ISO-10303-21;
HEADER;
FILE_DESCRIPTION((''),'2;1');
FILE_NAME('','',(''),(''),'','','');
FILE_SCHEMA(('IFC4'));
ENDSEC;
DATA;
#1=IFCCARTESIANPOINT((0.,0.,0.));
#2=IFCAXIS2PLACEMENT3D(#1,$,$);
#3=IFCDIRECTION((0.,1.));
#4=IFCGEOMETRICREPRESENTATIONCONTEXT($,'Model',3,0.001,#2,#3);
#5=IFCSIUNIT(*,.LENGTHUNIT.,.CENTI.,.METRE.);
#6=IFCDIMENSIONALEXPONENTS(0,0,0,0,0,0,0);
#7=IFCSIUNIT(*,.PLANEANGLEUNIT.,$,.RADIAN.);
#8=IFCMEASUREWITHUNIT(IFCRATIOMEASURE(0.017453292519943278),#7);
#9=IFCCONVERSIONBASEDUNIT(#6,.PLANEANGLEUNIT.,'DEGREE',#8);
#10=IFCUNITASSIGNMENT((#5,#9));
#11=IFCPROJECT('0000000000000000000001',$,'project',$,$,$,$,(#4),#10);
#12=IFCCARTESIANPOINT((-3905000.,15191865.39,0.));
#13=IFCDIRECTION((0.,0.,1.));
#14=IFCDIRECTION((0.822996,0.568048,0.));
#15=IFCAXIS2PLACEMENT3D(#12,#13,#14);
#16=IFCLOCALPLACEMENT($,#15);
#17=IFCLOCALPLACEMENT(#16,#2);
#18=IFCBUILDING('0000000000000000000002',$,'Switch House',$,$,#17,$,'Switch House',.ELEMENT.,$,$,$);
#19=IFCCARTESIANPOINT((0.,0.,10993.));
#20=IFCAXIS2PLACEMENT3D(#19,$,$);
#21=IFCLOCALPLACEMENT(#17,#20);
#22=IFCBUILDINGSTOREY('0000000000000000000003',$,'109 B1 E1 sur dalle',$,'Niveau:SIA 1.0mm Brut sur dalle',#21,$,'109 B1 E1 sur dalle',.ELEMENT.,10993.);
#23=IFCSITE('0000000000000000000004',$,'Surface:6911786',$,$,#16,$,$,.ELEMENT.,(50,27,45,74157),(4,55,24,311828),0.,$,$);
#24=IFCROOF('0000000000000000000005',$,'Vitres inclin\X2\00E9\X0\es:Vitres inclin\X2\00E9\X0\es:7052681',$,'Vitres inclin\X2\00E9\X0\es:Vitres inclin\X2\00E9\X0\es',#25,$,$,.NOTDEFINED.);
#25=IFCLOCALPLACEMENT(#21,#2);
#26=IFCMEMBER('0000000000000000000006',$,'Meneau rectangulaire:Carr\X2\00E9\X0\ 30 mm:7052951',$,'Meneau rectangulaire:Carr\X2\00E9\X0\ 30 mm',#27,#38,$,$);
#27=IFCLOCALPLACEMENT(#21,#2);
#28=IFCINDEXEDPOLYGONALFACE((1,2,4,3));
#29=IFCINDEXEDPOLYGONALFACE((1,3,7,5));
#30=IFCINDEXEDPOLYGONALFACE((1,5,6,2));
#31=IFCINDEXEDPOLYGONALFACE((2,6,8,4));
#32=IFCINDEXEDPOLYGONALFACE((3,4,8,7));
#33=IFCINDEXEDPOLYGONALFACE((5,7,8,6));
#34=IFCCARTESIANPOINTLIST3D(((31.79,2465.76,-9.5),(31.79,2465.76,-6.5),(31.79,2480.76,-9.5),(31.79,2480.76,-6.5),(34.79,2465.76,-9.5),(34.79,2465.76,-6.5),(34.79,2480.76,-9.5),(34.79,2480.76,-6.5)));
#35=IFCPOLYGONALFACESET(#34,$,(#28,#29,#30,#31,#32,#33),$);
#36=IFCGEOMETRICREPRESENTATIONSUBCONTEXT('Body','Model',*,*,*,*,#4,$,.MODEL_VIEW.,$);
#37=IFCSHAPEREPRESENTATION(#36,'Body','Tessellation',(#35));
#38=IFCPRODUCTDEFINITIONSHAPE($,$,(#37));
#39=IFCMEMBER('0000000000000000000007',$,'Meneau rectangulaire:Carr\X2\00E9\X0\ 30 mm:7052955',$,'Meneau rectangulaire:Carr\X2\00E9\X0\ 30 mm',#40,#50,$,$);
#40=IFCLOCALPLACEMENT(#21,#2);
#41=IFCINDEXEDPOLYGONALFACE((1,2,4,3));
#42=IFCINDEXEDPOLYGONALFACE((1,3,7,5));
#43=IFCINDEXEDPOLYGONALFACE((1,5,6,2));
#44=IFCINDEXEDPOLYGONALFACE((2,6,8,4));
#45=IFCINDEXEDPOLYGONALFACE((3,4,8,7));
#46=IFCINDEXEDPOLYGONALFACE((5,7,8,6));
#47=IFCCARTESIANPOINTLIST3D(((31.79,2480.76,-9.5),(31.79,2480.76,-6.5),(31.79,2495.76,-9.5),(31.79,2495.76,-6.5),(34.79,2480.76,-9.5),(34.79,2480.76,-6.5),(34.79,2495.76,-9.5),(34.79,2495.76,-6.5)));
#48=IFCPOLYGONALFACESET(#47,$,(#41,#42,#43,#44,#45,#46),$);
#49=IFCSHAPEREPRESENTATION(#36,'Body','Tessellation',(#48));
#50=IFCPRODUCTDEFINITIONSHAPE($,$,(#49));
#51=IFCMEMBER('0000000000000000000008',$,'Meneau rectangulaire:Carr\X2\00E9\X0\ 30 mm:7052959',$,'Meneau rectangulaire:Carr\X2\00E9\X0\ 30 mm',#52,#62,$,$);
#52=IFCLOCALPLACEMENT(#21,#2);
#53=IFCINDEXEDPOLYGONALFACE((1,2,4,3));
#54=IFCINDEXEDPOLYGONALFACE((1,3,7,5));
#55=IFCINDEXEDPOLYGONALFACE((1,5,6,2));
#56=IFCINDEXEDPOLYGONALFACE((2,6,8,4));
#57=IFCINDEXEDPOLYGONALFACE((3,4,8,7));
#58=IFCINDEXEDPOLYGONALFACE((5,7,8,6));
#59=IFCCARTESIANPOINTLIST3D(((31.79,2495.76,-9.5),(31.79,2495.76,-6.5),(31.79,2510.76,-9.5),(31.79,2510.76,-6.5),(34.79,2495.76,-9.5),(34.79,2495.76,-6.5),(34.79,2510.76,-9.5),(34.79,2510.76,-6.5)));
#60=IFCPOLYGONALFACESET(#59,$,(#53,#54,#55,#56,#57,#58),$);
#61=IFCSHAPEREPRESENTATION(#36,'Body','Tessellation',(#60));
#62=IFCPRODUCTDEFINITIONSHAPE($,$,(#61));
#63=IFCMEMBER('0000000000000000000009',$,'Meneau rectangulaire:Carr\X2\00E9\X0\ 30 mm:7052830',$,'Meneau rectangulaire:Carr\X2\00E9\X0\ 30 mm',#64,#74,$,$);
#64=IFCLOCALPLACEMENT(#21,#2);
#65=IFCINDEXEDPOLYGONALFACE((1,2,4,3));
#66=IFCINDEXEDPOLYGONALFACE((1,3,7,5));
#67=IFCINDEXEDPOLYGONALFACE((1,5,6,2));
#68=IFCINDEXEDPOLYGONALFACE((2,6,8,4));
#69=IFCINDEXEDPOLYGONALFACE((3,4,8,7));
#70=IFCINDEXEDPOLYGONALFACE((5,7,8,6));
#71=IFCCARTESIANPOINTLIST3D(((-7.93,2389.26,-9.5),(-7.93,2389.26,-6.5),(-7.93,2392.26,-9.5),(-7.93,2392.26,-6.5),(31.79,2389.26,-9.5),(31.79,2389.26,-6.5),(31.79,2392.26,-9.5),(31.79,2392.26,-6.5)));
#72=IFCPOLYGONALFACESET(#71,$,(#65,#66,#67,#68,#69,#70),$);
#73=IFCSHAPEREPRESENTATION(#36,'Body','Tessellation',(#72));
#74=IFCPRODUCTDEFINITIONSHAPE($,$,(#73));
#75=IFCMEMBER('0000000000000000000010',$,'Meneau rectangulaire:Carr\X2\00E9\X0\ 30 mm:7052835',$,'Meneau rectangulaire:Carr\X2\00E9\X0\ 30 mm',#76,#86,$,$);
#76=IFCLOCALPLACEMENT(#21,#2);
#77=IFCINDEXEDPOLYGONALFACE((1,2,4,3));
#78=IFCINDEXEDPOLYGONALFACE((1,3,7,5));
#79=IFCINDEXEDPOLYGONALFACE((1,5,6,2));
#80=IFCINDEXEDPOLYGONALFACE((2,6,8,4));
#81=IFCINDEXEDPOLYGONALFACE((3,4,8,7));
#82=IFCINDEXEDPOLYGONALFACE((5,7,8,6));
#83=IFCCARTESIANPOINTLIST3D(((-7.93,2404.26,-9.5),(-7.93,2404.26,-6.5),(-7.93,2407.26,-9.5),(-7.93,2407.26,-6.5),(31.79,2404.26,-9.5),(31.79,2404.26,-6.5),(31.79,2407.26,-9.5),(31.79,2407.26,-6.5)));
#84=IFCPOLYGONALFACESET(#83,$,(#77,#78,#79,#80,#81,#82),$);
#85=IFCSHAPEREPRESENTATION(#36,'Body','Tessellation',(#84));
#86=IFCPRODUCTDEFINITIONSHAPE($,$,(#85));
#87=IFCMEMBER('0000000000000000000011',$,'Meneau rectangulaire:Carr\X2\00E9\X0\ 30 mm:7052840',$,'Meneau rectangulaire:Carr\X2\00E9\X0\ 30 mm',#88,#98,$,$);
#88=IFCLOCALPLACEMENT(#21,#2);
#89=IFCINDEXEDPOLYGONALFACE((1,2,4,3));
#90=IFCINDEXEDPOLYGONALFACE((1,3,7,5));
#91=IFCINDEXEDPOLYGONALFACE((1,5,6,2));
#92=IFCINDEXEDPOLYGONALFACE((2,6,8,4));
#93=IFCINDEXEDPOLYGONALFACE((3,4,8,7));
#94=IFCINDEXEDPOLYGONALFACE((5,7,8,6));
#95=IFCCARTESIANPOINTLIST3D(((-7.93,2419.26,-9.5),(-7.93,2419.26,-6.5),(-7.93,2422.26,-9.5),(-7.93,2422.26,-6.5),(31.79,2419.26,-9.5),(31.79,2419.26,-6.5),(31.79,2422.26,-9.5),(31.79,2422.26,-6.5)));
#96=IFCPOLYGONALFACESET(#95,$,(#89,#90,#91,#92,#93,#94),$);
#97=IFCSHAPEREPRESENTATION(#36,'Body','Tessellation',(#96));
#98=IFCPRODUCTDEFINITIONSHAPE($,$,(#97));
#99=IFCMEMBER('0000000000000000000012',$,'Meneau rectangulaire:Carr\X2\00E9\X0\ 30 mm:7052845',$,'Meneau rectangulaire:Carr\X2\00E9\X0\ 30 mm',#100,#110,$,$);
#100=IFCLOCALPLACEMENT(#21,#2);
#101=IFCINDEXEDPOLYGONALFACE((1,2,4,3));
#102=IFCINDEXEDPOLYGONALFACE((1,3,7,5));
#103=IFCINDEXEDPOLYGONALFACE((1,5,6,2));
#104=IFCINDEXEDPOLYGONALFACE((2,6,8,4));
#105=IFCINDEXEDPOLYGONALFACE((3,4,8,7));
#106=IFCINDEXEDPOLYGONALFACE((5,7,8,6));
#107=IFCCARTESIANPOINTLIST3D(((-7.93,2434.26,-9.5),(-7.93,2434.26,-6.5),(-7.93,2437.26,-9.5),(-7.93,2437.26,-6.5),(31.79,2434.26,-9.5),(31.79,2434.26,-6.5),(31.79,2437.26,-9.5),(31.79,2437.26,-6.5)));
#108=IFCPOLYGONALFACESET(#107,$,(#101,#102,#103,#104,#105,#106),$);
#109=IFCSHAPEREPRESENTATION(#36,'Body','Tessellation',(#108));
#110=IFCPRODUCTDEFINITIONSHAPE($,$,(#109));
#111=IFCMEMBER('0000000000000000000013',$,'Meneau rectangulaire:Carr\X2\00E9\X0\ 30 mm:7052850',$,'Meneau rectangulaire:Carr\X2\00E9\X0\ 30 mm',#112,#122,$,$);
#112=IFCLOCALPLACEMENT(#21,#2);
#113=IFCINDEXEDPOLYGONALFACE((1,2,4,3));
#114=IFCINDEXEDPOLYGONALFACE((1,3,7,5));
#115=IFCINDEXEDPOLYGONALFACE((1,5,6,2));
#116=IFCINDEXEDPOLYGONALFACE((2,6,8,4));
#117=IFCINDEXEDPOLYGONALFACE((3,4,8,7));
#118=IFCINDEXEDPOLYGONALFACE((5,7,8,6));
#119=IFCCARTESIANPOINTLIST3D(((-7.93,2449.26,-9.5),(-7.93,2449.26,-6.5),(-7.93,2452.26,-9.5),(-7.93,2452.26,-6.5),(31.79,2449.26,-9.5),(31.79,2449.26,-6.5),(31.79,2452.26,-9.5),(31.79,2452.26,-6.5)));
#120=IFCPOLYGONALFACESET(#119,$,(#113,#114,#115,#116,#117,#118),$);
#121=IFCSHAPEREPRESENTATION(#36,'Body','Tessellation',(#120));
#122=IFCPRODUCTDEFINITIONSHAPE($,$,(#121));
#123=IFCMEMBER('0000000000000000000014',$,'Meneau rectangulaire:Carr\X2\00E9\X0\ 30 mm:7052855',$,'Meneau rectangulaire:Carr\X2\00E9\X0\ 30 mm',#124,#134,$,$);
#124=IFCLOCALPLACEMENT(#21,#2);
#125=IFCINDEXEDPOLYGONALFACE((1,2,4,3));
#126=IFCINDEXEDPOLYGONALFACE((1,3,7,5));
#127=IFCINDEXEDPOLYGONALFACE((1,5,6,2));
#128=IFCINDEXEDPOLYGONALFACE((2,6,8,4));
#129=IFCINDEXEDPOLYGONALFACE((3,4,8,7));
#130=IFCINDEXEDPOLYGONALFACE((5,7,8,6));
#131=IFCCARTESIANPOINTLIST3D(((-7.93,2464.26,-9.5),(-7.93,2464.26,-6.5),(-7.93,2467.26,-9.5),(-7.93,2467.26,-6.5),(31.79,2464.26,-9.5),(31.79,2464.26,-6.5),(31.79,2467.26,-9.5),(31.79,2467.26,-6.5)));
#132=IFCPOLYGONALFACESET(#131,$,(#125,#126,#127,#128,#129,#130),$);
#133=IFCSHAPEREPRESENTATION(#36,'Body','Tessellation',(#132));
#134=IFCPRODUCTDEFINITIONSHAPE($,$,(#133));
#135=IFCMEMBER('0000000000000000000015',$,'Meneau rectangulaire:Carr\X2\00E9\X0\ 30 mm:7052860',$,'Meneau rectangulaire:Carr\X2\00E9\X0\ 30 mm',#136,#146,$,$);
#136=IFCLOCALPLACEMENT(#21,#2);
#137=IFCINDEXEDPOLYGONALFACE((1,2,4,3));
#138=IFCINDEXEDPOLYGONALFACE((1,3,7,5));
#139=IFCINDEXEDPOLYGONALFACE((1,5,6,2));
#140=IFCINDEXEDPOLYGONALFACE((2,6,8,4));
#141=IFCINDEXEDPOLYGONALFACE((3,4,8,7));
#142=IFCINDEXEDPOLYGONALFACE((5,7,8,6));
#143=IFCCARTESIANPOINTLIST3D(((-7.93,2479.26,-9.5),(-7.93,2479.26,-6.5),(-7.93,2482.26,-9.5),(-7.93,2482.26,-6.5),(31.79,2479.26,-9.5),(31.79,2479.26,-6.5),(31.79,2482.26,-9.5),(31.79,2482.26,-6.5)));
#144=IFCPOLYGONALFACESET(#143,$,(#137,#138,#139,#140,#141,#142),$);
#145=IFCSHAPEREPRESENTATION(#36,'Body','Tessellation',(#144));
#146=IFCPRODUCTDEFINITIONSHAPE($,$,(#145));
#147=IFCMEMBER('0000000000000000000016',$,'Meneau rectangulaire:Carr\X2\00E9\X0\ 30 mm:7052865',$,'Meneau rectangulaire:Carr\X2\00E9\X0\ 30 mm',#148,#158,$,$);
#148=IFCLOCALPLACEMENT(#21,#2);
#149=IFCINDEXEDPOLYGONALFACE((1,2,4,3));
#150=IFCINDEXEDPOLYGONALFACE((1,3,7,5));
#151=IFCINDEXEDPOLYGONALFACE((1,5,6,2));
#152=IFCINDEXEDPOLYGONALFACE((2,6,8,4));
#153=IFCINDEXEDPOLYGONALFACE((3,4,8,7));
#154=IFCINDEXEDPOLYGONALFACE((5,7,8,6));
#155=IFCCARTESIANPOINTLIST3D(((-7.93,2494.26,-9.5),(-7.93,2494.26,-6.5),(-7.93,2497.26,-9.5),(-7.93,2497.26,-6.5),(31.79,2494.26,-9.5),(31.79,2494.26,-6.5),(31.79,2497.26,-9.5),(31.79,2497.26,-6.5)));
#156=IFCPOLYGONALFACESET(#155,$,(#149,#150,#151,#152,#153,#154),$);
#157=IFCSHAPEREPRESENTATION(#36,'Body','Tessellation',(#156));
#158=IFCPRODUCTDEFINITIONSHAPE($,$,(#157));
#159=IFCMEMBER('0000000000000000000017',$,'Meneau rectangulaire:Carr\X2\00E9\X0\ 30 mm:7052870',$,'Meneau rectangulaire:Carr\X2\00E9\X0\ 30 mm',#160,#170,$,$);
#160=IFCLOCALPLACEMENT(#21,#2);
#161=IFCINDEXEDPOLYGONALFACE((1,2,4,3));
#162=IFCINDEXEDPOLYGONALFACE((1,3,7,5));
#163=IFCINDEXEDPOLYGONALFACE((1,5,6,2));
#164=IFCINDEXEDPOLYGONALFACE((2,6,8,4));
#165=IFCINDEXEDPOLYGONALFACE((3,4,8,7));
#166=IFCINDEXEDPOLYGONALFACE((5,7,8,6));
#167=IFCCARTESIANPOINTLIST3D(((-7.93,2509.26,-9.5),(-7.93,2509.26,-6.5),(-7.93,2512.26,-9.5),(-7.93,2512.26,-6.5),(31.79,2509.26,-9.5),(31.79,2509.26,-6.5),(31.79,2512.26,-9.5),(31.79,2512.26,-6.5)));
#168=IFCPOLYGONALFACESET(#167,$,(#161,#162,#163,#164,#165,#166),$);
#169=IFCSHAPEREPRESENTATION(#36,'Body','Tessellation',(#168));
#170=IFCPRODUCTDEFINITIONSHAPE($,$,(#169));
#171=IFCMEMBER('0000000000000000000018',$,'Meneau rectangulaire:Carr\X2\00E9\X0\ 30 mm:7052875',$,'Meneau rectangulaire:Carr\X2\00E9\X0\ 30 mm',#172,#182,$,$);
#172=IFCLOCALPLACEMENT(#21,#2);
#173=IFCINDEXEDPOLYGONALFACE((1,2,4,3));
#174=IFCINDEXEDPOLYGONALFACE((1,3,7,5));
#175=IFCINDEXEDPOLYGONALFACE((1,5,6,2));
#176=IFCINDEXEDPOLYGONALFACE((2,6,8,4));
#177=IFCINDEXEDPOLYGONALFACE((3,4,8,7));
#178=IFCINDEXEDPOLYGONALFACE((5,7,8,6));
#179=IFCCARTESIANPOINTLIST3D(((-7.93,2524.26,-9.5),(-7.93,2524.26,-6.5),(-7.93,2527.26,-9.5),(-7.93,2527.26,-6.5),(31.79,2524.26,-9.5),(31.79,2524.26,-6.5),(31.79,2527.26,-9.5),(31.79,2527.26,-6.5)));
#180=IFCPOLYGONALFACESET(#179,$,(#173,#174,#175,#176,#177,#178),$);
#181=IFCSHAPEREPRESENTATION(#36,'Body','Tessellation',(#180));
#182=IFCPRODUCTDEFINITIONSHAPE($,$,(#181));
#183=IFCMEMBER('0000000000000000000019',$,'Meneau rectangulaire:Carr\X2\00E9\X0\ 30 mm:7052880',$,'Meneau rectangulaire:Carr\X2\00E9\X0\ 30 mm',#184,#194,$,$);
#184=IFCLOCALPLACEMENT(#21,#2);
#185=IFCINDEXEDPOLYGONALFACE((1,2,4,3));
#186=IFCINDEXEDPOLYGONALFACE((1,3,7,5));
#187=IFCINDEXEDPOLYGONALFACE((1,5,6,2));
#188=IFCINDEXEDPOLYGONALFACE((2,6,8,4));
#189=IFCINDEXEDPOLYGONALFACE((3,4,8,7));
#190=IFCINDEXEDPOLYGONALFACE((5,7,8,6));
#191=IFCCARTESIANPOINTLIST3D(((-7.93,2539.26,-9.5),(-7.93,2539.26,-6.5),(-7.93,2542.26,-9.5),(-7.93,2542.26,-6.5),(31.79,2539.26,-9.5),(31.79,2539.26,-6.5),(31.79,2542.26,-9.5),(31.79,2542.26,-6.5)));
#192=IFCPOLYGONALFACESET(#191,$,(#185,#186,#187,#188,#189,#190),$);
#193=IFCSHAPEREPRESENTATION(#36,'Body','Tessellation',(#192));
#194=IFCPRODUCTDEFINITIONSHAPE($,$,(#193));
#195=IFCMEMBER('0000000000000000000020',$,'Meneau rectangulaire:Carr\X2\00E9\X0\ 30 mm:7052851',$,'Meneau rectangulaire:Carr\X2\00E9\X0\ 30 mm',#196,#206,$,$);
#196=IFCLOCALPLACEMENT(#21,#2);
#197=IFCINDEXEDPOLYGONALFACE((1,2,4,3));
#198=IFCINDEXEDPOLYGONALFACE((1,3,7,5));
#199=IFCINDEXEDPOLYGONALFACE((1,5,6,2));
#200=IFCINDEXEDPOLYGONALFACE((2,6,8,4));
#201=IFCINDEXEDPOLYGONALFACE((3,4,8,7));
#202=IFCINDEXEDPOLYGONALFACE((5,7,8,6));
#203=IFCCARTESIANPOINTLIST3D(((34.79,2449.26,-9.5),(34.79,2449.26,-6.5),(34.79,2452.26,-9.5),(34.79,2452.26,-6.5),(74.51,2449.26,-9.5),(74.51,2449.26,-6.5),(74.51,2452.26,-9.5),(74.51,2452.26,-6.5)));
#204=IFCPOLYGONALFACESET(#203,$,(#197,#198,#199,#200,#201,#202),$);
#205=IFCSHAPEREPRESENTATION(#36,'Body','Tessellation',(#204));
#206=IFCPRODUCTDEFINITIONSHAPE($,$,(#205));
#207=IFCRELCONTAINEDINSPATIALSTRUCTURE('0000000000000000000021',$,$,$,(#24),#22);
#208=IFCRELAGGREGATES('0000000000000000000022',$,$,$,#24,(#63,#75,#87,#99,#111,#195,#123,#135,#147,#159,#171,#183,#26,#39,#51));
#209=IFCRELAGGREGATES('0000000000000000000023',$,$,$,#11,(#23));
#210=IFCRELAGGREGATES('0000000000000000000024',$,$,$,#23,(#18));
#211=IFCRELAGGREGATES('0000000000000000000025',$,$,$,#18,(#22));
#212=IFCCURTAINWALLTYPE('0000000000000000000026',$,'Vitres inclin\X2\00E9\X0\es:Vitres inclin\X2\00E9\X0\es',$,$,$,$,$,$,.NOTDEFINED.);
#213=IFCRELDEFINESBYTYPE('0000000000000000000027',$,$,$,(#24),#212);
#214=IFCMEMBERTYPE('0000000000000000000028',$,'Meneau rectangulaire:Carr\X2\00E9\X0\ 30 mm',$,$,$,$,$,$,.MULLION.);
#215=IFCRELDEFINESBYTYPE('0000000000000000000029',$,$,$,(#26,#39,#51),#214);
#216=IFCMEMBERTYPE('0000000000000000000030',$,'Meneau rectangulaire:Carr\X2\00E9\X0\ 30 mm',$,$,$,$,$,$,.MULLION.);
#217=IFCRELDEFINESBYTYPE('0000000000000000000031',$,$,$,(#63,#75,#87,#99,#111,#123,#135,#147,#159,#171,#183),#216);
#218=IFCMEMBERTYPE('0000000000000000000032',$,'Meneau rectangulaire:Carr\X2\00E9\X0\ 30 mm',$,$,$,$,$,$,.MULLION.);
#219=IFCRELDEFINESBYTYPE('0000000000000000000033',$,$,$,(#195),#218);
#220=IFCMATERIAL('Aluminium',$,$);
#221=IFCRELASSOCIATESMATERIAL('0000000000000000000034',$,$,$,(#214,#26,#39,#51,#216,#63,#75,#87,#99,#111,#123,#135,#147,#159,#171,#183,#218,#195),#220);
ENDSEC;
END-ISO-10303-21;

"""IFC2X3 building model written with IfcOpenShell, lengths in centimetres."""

from ifc_helpers import new_model, entity, si_unit, converted_unit, direction, frame, origin, origin_2d_with_axis, place, context, subcontext, project, spatial, rectangle, extrude, source, transform, mapped, material, type_object, type_shapes, element, aggregate, save


model = new_model("IFC2X3")

# Units and contexts
model_context = context("Model", 3, precision=0.001, world=origin(), true_north=direction((0.0, 1.0)))
body_context = subcontext(model_context, "Body", "Model", "MODEL_VIEW")
ifc_project = project(units=[si_unit("LENGTHUNIT", "METRE", prefix="CENTI"), converted_unit("PLANEANGLEUNIT", "DEGREE", entity("IfcRatioMeasure", 0.017453292519943278), si_unit("PLANEANGLEUNIT", "RADIAN"), dimensions=[0, 0, 0, 0, 0, 0, 0])], contexts=[model_context])

# Site, building, storey
site_placement = place(None, frame((-3905000.0, 15191865.39, 0.0), z_axis=(0.0, 0.0, 1.0), x_axis=(0.822996, 0.568048, 0.0)))
site = spatial("IfcSite", under=ifc_project, at=site_placement, Name="Surface:6911786", CompositionType="ELEMENT", RefLatitude=(50, 27, 45, 74157), RefLongitude=(4, 55, 24, 311828), RefElevation=0.0)
building_placement = place(site_placement, origin())
building = spatial("IfcBuilding", under=site, at=building_placement, Name="Switch House", LongName="Switch House", CompositionType="ELEMENT")
storey_placement = place(building_placement, frame((0.0, 0.0, 10993.0)))
storey = spatial("IfcBuildingStorey", under=building, at=storey_placement, Name="109 B1 E1 sur dalle", ObjectType="Niveau:SIA 1.0mm Brut sur dalle", LongName="109 B1 E1 sur dalle", CompositionType="ELEMENT", Elevation=10993.0)

# Roof, members
curtain_wall_type = type_object("IfcCurtainWallType", Name="Vitres inclinées:Vitres inclinées", PredefinedType="NOTDEFINED")
ifc_material = material(Name="Aluminium")
member_type_1 = type_object("IfcMemberType", Name="Meneau rectangulaire:Carré 30 mm", PredefinedType="MULLION", material=ifc_material)
shared_shape_1 = source(origin(), body_context, "Body", "SweptSolid", [
    extrude(rectangle(XDim=3.0, YDim=3.0, at=origin_2d_with_axis()), frame((0.0, 0.0, -15.0), z_axis=(0.0, 0.0, 1.0), x_axis=(0.0, -1.0, 0.0)), (0.0, 0.0, 1.0), 15.0),
])
type_shapes(member_type_1, [shared_shape_1])
roof_1_placement = place(storey_placement, frame((0.0, 0.0, -10993.0)))
roof_1 = element("IfcRoof", 1, at=roof_1_placement, inside=storey, type_object=curtain_wall_type, Name="Vitres inclinées:Vitres inclinées:7052681", ObjectType="Vitres inclinées:Vitres inclinées", ShapeType="NOTDEFINED")
member_1_placement = place(roof_1_placement, frame((33.29, 2480.76, 10985.0), z_axis=(0.0, 1.0, 0.0), x_axis=(1.0, 0.0, 0.0)))
member_1 = element("IfcMember", 2, at=member_1_placement, type_object=member_type_1, material=ifc_material, Name="Meneau rectangulaire:Carré 30 mm:7052951", ObjectType="Meneau rectangulaire:Carré 30 mm", context=body_context, shape_type="MappedRepresentation", body=[
    mapped(shared_shape_1, transform((0.0, 0.0, 0.0), scale=1.0)),
])
member_2_placement = place(roof_1_placement, frame((33.29, 2495.76, 10985.0), z_axis=(0.0, 1.0, 0.0), x_axis=(1.0, 0.0, 0.0)))
member_2 = element("IfcMember", 3, at=member_2_placement, type_object=member_type_1, material=ifc_material, Name="Meneau rectangulaire:Carré 30 mm:7052955", ObjectType="Meneau rectangulaire:Carré 30 mm", context=body_context, shape_type="MappedRepresentation", body=[
    mapped(shared_shape_1, transform((0.0, 0.0, 0.0), scale=1.0)),
])
member_3_placement = place(roof_1_placement, frame((33.29, 2510.76, 10985.0), z_axis=(0.0, 1.0, 0.0), x_axis=(1.0, 0.0, 0.0)))
member_3 = element("IfcMember", 4, at=member_3_placement, type_object=member_type_1, material=ifc_material, Name="Meneau rectangulaire:Carré 30 mm:7052959", ObjectType="Meneau rectangulaire:Carré 30 mm", context=body_context, shape_type="MappedRepresentation", body=[
    mapped(shared_shape_1, transform((0.0, 0.0, 0.0), scale=1.0)),
])
member_type_2 = type_object("IfcMemberType", Name="Meneau rectangulaire:Carré 30 mm", PredefinedType="MULLION", material=ifc_material)
shared_shape_2 = source(origin(), body_context, "Body", "SweptSolid", [
    extrude(rectangle(XDim=3.0, YDim=3.0, at=origin_2d_with_axis()), frame((0.0, 0.0, -39.72), z_axis=(0.0, 0.0, 1.0), x_axis=(0.0, -1.0, 0.0)), (0.0, 0.0, 1.0), 39.72),
])
type_shapes(member_type_2, [shared_shape_2])
member_4_placement = place(roof_1_placement, frame((-7.93, 2390.76, 10985.0), z_axis=(-1.0, 0.0, 0.0), x_axis=(0.0, 1.0, 0.0)))
member_4 = element("IfcMember", 5, at=member_4_placement, type_object=member_type_2, material=ifc_material, Name="Meneau rectangulaire:Carré 30 mm:7052830", ObjectType="Meneau rectangulaire:Carré 30 mm", context=body_context, shape_type="MappedRepresentation", body=[
    mapped(shared_shape_2, transform((0.0, 0.0, 0.0), scale=1.0)),
])
member_5_placement = place(roof_1_placement, frame((-7.93, 2405.76, 10985.0), z_axis=(-1.0, 0.0, 0.0), x_axis=(0.0, 1.0, 0.0)))
member_5 = element("IfcMember", 6, at=member_5_placement, type_object=member_type_2, material=ifc_material, Name="Meneau rectangulaire:Carré 30 mm:7052835", ObjectType="Meneau rectangulaire:Carré 30 mm", context=body_context, shape_type="MappedRepresentation", body=[
    mapped(shared_shape_2, transform((0.0, 0.0, 0.0), scale=1.0)),
])
member_6_placement = place(roof_1_placement, frame((-7.93, 2420.76, 10985.0), z_axis=(-1.0, 0.0, 0.0), x_axis=(0.0, 1.0, 0.0)))
member_6 = element("IfcMember", 7, at=member_6_placement, type_object=member_type_2, material=ifc_material, Name="Meneau rectangulaire:Carré 30 mm:7052840", ObjectType="Meneau rectangulaire:Carré 30 mm", context=body_context, shape_type="MappedRepresentation", body=[
    mapped(shared_shape_2, transform((0.0, 0.0, 0.0), scale=1.0)),
])
member_7_placement = place(roof_1_placement, frame((-7.93, 2435.76, 10985.0), z_axis=(-1.0, 0.0, 0.0), x_axis=(0.0, 1.0, 0.0)))
member_7 = element("IfcMember", 8, at=member_7_placement, type_object=member_type_2, material=ifc_material, Name="Meneau rectangulaire:Carré 30 mm:7052845", ObjectType="Meneau rectangulaire:Carré 30 mm", context=body_context, shape_type="MappedRepresentation", body=[
    mapped(shared_shape_2, transform((0.0, 0.0, 0.0), scale=1.0)),
])
member_8_placement = place(roof_1_placement, frame((-7.93, 2450.76, 10985.0), z_axis=(-1.0, 0.0, 0.0), x_axis=(0.0, 1.0, 0.0)))
member_8 = element("IfcMember", 9, at=member_8_placement, type_object=member_type_2, material=ifc_material, Name="Meneau rectangulaire:Carré 30 mm:7052850", ObjectType="Meneau rectangulaire:Carré 30 mm", context=body_context, shape_type="MappedRepresentation", body=[
    mapped(shared_shape_2, transform((0.0, 0.0, 0.0), scale=1.0)),
])
member_9_placement = place(roof_1_placement, frame((-7.93, 2465.76, 10985.0), z_axis=(-1.0, 0.0, 0.0), x_axis=(0.0, 1.0, 0.0)))
member_9 = element("IfcMember", 10, at=member_9_placement, type_object=member_type_2, material=ifc_material, Name="Meneau rectangulaire:Carré 30 mm:7052855", ObjectType="Meneau rectangulaire:Carré 30 mm", context=body_context, shape_type="MappedRepresentation", body=[
    mapped(shared_shape_2, transform((0.0, 0.0, 0.0), scale=1.0)),
])
member_10_placement = place(roof_1_placement, frame((-7.93, 2480.76, 10985.0), z_axis=(-1.0, 0.0, 0.0), x_axis=(0.0, 1.0, 0.0)))
member_10 = element("IfcMember", 11, at=member_10_placement, type_object=member_type_2, material=ifc_material, Name="Meneau rectangulaire:Carré 30 mm:7052860", ObjectType="Meneau rectangulaire:Carré 30 mm", context=body_context, shape_type="MappedRepresentation", body=[
    mapped(shared_shape_2, transform((0.0, 0.0, 0.0), scale=1.0)),
])
member_11_placement = place(roof_1_placement, frame((-7.93, 2495.76, 10985.0), z_axis=(-1.0, 0.0, 0.0), x_axis=(0.0, 1.0, 0.0)))
member_11 = element("IfcMember", 12, at=member_11_placement, type_object=member_type_2, material=ifc_material, Name="Meneau rectangulaire:Carré 30 mm:7052865", ObjectType="Meneau rectangulaire:Carré 30 mm", context=body_context, shape_type="MappedRepresentation", body=[
    mapped(shared_shape_2, transform((0.0, 0.0, 0.0), scale=1.0)),
])
member_12_placement = place(roof_1_placement, frame((-7.93, 2510.76, 10985.0), z_axis=(-1.0, 0.0, 0.0), x_axis=(0.0, 1.0, 0.0)))
member_12 = element("IfcMember", 13, at=member_12_placement, type_object=member_type_2, material=ifc_material, Name="Meneau rectangulaire:Carré 30 mm:7052870", ObjectType="Meneau rectangulaire:Carré 30 mm", context=body_context, shape_type="MappedRepresentation", body=[
    mapped(shared_shape_2, transform((0.0, 0.0, 0.0), scale=1.0)),
])
member_13_placement = place(roof_1_placement, frame((-7.93, 2525.76, 10985.0), z_axis=(-1.0, 0.0, 0.0), x_axis=(0.0, 1.0, 0.0)))
member_13 = element("IfcMember", 14, at=member_13_placement, type_object=member_type_2, material=ifc_material, Name="Meneau rectangulaire:Carré 30 mm:7052875", ObjectType="Meneau rectangulaire:Carré 30 mm", context=body_context, shape_type="MappedRepresentation", body=[
    mapped(shared_shape_2, transform((0.0, 0.0, 0.0), scale=1.0)),
])
member_14_placement = place(roof_1_placement, frame((-7.93, 2540.76, 10985.0), z_axis=(-1.0, 0.0, 0.0), x_axis=(0.0, 1.0, 0.0)))
member_14 = element("IfcMember", 15, at=member_14_placement, type_object=member_type_2, material=ifc_material, Name="Meneau rectangulaire:Carré 30 mm:7052880", ObjectType="Meneau rectangulaire:Carré 30 mm", context=body_context, shape_type="MappedRepresentation", body=[
    mapped(shared_shape_2, transform((0.0, 0.0, 0.0), scale=1.0)),
])
member_type_3 = type_object("IfcMemberType", Name="Meneau rectangulaire:Carré 30 mm", PredefinedType="MULLION", material=ifc_material)
shared_shape_3 = source(origin(), body_context, "Body", "SweptSolid", [
    extrude(rectangle(XDim=3.0, YDim=3.0, at=origin_2d_with_axis()), frame((0.0, 0.0, -39.72), z_axis=(0.0, 0.0, 1.0), x_axis=(0.0, -1.0, 0.0)), (0.0, 0.0, 1.0), 39.72),
])
type_shapes(member_type_3, [shared_shape_3])
member_15_placement = place(roof_1_placement, frame((34.79, 2450.76, 10985.0), z_axis=(-1.0, 0.0, 0.0), x_axis=(0.0, 1.0, 0.0)))
member_15 = element("IfcMember", 16, at=member_15_placement, type_object=member_type_3, material=ifc_material, Name="Meneau rectangulaire:Carré 30 mm:7052851", ObjectType="Meneau rectangulaire:Carré 30 mm", context=body_context, shape_type="MappedRepresentation", body=[
    mapped(shared_shape_3, transform((0.0, 0.0, 0.0), scale=1.0)),
])
aggregate(roof_1, [member_4, member_5, member_6, member_7, member_8, member_15, member_9, member_10, member_11, member_12, member_13, member_14, member_1, member_2, member_3])

save(model, "model.ifc")
